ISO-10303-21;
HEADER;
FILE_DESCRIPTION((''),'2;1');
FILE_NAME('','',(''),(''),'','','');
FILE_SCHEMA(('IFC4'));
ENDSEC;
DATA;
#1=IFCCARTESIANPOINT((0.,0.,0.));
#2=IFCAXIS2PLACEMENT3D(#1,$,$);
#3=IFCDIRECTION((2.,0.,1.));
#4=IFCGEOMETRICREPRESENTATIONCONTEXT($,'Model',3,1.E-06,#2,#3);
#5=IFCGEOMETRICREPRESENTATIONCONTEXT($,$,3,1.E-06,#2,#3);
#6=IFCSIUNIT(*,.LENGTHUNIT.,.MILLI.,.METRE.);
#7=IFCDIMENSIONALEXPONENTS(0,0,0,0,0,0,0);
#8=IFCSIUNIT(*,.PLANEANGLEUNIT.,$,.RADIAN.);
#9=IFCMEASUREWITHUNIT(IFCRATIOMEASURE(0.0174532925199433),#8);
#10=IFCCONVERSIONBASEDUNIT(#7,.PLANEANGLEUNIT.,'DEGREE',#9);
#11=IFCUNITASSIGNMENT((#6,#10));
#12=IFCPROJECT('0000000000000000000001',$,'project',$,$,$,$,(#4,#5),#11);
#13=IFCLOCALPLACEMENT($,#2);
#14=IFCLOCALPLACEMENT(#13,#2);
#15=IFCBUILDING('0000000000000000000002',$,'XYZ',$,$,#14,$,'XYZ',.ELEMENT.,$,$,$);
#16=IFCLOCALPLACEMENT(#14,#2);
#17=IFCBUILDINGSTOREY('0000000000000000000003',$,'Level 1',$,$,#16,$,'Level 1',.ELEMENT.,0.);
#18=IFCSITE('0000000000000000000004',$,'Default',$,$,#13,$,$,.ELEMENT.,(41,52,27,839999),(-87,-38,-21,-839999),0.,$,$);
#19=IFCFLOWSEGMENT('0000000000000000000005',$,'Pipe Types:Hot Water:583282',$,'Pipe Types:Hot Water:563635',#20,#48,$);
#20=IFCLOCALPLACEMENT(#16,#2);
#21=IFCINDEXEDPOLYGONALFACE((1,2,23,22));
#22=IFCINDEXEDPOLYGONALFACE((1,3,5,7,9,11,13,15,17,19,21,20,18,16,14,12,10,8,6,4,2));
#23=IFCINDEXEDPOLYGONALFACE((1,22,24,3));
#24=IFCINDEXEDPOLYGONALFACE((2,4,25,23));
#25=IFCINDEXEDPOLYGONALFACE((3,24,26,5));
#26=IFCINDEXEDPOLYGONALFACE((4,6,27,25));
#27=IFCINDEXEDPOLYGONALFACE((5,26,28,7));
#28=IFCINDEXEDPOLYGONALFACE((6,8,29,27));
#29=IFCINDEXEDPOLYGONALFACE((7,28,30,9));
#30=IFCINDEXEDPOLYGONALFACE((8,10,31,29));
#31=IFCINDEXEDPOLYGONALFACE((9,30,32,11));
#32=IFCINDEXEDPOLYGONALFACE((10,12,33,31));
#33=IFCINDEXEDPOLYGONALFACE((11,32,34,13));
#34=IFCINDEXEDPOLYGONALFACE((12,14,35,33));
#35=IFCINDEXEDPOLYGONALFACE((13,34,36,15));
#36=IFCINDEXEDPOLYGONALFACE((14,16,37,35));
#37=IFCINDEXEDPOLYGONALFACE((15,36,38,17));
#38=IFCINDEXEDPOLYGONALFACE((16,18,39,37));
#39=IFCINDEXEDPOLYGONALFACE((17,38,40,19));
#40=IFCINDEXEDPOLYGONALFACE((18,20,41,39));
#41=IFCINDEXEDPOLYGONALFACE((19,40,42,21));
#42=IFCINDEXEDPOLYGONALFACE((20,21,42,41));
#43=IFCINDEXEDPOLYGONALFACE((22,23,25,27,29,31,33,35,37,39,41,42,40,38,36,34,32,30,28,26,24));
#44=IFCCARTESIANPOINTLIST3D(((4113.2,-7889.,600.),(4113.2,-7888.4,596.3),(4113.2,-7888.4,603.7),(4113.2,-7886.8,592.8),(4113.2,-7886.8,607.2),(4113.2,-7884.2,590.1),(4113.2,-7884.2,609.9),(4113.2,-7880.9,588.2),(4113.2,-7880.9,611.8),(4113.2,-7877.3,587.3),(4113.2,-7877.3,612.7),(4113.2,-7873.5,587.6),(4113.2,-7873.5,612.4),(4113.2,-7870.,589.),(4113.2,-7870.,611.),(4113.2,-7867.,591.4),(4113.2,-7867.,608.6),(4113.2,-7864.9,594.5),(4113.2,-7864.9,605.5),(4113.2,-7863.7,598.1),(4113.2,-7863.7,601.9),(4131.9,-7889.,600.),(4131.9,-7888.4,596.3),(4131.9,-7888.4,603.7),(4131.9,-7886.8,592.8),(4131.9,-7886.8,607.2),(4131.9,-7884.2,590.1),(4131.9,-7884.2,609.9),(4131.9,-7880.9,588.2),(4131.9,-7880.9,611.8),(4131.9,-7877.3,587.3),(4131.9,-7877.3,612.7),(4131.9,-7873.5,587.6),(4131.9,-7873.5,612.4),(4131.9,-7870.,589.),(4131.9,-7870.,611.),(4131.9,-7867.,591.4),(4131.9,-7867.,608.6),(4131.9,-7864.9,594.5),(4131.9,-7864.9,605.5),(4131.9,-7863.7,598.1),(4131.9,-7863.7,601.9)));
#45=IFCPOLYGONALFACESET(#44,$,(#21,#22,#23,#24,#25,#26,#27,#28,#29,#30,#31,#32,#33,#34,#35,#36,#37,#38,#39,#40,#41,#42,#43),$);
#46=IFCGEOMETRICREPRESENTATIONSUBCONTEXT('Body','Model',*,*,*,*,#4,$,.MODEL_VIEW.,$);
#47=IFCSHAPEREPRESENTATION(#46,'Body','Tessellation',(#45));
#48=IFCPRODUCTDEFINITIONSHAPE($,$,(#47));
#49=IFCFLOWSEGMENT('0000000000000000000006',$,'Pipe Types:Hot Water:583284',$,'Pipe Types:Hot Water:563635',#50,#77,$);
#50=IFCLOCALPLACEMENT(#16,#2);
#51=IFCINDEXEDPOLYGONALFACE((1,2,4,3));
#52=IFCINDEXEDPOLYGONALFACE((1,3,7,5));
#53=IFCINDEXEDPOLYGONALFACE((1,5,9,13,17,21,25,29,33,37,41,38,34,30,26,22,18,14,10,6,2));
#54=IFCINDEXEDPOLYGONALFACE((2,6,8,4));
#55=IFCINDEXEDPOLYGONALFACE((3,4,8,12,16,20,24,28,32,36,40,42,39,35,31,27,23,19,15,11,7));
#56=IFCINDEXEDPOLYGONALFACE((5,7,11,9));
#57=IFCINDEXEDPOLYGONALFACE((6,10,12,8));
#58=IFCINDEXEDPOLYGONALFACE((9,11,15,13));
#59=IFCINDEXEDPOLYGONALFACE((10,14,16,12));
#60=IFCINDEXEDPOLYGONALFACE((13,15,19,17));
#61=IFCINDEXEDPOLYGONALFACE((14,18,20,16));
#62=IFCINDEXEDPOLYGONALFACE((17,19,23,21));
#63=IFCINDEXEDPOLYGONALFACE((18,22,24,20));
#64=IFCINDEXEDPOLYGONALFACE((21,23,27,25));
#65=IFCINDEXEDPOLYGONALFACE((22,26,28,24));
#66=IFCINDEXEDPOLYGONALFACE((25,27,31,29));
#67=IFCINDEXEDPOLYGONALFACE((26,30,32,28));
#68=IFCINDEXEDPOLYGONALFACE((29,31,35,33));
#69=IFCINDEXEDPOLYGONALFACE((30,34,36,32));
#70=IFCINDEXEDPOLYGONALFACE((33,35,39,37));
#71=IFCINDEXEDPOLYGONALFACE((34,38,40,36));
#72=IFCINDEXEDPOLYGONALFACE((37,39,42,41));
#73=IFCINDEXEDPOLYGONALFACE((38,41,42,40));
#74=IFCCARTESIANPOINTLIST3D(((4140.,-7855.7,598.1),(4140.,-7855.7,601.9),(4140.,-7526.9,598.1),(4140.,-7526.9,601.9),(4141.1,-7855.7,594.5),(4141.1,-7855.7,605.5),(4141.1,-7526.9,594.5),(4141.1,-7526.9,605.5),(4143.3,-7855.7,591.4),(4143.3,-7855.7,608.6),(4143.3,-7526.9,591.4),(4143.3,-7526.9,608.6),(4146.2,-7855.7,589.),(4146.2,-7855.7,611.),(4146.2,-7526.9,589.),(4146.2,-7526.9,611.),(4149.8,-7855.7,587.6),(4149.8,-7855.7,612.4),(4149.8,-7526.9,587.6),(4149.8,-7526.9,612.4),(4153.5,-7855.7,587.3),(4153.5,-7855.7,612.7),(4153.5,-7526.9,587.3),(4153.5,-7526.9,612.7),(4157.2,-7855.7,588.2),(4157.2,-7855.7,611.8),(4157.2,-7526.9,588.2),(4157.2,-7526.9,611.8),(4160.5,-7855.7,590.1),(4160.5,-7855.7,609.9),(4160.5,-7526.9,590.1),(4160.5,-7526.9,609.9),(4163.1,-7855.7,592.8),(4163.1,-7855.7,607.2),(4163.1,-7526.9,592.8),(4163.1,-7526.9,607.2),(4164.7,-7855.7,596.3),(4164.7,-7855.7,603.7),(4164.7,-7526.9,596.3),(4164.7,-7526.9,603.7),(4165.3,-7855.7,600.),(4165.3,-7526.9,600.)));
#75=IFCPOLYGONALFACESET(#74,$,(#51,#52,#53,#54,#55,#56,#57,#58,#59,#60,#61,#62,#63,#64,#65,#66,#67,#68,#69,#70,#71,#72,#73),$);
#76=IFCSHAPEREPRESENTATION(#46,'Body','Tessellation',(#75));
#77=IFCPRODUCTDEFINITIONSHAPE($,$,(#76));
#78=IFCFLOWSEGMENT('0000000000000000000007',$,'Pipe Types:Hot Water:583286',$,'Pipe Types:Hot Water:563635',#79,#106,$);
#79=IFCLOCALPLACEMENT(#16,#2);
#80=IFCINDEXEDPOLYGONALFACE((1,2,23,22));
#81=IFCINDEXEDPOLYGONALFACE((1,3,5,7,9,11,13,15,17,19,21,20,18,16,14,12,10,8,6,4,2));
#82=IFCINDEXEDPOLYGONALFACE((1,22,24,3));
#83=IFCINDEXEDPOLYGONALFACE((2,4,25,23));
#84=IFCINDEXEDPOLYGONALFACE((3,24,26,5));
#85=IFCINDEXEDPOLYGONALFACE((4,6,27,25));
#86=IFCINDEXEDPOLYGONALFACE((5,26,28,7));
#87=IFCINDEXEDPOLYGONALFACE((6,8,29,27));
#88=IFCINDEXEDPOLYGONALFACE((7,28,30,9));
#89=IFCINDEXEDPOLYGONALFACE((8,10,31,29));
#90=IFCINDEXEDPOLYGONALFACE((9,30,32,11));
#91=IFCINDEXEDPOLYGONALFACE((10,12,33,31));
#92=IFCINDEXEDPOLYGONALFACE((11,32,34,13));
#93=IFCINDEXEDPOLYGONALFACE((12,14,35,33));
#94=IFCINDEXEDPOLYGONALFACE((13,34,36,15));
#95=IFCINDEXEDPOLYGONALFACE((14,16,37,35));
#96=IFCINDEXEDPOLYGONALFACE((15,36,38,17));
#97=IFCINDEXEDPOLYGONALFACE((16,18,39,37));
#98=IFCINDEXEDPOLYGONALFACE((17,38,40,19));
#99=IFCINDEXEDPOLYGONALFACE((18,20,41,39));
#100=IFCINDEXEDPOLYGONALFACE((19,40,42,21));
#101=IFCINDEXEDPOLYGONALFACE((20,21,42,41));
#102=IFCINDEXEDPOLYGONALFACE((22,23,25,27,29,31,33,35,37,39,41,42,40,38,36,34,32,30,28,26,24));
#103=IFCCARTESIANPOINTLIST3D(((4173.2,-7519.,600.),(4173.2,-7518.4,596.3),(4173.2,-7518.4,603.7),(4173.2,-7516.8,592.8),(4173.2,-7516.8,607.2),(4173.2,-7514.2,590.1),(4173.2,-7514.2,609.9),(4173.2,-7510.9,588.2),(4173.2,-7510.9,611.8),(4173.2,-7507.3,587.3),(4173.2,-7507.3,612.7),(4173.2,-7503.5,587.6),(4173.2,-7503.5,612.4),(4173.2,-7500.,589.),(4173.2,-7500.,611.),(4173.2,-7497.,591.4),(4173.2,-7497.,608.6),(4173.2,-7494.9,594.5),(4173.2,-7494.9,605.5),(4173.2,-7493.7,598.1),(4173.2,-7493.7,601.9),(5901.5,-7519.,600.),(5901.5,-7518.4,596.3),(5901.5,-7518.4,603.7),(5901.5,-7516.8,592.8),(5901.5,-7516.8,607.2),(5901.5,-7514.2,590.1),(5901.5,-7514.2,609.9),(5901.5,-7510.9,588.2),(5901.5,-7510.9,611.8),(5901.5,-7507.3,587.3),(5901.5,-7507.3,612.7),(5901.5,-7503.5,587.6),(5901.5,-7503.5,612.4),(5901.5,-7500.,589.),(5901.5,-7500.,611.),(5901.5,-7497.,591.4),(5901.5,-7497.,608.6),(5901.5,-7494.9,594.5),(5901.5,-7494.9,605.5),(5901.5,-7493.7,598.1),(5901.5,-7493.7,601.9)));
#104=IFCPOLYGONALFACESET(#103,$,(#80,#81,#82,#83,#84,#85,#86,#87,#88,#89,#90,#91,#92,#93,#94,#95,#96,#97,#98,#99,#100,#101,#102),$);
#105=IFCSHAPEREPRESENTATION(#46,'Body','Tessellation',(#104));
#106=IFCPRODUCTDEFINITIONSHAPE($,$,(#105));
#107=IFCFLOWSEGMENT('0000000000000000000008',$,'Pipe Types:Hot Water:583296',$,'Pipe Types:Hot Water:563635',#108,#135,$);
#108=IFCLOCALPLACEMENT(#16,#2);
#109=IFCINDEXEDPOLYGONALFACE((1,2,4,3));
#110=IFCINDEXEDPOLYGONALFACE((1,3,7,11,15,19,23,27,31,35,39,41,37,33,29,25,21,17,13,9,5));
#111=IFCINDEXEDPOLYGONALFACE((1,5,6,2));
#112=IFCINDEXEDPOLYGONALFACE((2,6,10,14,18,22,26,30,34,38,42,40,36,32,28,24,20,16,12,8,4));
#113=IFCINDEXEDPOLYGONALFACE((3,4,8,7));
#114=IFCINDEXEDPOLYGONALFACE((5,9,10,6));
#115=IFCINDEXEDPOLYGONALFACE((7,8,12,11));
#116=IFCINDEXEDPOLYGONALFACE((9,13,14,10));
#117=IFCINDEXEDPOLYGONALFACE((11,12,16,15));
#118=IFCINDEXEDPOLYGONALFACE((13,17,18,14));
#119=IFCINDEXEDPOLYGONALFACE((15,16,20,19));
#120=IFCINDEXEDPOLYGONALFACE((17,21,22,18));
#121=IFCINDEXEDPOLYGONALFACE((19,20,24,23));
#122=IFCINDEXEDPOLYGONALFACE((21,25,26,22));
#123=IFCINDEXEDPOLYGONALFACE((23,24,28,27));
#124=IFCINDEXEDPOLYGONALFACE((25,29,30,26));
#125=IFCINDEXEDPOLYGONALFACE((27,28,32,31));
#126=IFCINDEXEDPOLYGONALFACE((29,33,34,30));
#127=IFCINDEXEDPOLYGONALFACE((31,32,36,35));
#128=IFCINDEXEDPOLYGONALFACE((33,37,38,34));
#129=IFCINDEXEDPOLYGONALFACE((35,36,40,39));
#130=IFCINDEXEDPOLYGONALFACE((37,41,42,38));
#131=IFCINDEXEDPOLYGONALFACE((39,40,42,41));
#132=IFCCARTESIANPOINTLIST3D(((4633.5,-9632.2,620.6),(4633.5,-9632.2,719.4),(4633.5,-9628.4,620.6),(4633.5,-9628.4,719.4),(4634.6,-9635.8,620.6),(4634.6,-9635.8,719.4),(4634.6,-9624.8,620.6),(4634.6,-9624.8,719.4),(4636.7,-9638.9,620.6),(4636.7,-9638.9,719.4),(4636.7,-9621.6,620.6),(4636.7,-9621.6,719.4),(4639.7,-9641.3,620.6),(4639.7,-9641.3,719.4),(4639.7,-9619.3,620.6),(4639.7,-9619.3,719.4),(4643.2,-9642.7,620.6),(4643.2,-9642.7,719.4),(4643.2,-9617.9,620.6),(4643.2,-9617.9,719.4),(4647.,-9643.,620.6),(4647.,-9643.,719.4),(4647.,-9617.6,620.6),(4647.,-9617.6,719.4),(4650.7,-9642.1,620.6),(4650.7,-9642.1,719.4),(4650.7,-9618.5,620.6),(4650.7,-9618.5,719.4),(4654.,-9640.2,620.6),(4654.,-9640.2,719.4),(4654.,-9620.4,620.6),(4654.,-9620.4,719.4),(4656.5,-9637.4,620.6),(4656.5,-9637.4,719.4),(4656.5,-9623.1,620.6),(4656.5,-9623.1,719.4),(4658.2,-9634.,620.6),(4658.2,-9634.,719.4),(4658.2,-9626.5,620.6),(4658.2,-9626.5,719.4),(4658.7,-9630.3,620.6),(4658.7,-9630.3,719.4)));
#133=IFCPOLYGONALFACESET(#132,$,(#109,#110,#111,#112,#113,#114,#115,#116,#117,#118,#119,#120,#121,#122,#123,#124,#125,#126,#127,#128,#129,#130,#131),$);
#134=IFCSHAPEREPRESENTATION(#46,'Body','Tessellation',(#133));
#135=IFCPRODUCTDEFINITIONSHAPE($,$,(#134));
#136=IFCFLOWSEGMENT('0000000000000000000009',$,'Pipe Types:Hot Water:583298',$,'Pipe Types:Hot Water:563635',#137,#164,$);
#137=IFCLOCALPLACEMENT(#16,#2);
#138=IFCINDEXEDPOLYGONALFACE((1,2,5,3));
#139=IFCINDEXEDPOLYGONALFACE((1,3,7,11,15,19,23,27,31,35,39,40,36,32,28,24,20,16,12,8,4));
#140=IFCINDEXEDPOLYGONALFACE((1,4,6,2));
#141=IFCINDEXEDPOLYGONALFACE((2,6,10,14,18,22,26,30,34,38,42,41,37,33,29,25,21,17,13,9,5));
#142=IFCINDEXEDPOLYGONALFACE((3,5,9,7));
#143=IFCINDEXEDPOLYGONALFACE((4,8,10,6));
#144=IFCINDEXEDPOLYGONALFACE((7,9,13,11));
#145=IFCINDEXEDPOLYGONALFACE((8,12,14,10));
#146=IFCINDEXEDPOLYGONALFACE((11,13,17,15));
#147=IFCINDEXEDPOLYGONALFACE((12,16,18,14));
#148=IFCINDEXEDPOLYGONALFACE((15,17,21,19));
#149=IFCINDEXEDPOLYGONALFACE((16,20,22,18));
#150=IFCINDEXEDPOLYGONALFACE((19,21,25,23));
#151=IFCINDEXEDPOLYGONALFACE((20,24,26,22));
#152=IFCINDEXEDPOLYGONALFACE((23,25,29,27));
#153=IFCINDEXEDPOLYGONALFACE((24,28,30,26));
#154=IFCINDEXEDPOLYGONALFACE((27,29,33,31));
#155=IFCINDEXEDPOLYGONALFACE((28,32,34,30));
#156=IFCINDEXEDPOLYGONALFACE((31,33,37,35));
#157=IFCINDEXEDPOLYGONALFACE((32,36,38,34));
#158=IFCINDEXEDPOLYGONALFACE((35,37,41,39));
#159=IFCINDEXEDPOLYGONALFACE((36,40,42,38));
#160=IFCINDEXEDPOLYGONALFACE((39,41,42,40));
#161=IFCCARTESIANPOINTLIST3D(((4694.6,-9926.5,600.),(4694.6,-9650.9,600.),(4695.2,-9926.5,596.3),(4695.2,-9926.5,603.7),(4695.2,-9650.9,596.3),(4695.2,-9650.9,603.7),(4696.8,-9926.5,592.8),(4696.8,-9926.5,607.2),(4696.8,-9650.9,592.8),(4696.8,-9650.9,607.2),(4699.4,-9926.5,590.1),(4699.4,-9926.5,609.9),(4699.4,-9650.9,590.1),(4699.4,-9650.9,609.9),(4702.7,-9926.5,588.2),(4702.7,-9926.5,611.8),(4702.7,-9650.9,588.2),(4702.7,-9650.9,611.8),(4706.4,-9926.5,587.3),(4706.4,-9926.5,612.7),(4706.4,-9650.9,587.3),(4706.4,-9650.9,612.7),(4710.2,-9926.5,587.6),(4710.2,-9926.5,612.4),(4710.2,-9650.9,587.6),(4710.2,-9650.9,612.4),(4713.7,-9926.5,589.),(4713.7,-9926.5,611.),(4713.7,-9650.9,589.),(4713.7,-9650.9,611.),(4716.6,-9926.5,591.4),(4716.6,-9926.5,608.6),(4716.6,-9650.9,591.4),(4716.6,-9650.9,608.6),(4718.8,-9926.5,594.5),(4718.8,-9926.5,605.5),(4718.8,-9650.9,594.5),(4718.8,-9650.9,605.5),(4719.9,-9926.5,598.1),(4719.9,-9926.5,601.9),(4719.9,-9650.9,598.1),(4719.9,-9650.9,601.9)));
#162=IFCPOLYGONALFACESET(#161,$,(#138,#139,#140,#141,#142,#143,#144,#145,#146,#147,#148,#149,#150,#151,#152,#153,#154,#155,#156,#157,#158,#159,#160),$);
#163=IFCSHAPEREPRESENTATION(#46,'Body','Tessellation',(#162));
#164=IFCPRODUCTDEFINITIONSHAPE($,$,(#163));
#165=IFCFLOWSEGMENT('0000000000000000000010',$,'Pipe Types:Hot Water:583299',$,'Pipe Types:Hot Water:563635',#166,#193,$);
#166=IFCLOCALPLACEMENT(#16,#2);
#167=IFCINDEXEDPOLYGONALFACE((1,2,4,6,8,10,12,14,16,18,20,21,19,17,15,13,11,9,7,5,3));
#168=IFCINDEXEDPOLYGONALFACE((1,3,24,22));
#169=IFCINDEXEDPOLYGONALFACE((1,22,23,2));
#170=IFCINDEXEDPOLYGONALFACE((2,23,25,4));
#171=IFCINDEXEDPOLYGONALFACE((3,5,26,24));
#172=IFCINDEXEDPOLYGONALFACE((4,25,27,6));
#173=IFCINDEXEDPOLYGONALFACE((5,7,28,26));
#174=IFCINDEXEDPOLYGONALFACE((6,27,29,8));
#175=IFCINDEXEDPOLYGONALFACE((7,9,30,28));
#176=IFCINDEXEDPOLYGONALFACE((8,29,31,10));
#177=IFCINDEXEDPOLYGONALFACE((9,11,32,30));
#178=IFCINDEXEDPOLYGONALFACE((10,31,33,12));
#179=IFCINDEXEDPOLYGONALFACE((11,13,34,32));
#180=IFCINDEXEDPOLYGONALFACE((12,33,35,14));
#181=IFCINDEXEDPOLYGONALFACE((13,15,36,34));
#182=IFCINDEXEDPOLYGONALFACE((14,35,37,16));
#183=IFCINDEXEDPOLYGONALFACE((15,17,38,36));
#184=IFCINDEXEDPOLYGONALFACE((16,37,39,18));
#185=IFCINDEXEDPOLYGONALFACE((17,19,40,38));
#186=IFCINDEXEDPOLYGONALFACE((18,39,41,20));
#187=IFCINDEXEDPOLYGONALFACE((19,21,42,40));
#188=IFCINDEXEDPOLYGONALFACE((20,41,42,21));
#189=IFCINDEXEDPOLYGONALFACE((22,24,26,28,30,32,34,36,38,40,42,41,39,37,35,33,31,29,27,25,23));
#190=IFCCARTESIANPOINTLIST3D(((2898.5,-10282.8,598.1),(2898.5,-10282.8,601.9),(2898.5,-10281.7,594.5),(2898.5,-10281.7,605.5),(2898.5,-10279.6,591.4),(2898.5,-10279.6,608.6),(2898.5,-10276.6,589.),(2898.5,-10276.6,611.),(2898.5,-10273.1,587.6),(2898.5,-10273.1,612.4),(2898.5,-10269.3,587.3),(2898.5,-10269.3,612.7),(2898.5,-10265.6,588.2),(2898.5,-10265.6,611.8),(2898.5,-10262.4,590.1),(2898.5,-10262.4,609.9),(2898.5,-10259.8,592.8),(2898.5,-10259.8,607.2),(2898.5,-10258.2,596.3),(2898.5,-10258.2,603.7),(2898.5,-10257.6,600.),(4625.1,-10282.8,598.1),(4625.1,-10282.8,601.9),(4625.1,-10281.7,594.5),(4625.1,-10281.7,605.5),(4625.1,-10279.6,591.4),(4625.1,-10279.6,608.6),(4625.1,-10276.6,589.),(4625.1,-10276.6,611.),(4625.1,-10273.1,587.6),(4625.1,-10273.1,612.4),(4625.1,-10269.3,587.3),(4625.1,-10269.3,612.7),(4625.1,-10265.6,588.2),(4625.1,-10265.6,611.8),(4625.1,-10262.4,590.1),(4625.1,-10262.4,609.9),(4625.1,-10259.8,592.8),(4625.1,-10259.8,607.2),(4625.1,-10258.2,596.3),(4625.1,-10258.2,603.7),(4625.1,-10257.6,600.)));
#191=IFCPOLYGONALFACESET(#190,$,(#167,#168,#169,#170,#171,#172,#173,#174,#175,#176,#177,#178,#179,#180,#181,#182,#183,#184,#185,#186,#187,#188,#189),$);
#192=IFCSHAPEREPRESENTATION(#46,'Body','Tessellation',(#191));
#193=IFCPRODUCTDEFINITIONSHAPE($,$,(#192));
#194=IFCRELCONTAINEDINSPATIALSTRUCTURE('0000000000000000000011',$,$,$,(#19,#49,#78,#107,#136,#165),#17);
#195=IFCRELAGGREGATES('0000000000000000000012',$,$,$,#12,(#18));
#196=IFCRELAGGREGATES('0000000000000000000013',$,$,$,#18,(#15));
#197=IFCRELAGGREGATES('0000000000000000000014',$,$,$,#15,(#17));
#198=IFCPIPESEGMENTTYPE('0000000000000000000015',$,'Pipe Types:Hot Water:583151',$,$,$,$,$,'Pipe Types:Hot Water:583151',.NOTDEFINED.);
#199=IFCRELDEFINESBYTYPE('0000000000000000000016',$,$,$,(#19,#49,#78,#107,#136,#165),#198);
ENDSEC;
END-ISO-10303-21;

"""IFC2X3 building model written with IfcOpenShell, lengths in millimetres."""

from ifc_helpers import new_model, entity, si_unit, converted_unit, direction, frame, frame_2d, origin, origin_2d_with_axis, place, context, subcontext, project, spatial, circle, extrude, type_object, element, save


model = new_model("IFC2X3")

# Units and contexts
model_context = context("Model", 3, precision=1e-06, world=origin(), true_north=direction((2.0, 0.0, 1.0)))
context_of_model = context(None, 3, precision=1e-06, world=origin(), true_north=direction((2.0, 0.0, 1.0)))
body_context = subcontext(model_context, "Body", "Model", "MODEL_VIEW")
ifc_project = project(units=[si_unit("LENGTHUNIT", "METRE", prefix="MILLI"), converted_unit("PLANEANGLEUNIT", "DEGREE", entity("IfcRatioMeasure", 0.0174532925199433), si_unit("PLANEANGLEUNIT", "RADIAN"), dimensions=[0, 0, 0, 0, 0, 0, 0])], contexts=[model_context, context_of_model])

# Site, building, storey
site_placement = place(None, origin())
site = spatial("IfcSite", under=ifc_project, at=site_placement, Name="Default", CompositionType="ELEMENT", RefLatitude=(41, 52, 27, 839999), RefLongitude=(-87, -38, -21, -839999), RefElevation=0.0)
building_placement = place(site_placement, origin())
building = spatial("IfcBuilding", under=site, at=building_placement, Name="XYZ", LongName="XYZ", CompositionType="ELEMENT")
storey_placement = place(building_placement, origin())
storey = spatial("IfcBuildingStorey", under=building, at=storey_placement, Name="Level 1", LongName="Level 1", CompositionType="ELEMENT", Elevation=0.0)

# Flow segments
pipe_segment_type_1 = type_object("IfcPipeSegmentType", Name="Pipe Types:Hot Water:583151", ElementType="Pipe Types:Hot Water:583151", PredefinedType="NOTDEFINED")
flow_segment_1_placement = place(storey_placement, origin())
element("IfcFlowSegment", 1, at=flow_segment_1_placement, inside=storey, type_object=pipe_segment_type_1, Name="Pipe Types:Hot Water:583282", ObjectType="Pipe Types:Hot Water:563635", context=body_context, shape_type="SweptSolid", body=[
    extrude(circle(Radius=12.7, at=origin_2d_with_axis()), frame((4113.2, -7876.3, 600.0), z_axis=(1.0, 0.0, 0.0), x_axis=(0.0, -1.0, 0.0)), (0.0, 0.0, 1.0), 18.7),
])
flow_segment_2_placement = place(storey_placement, origin())
element("IfcFlowSegment", 2, at=flow_segment_2_placement, inside=storey, type_object=pipe_segment_type_1, Name="Pipe Types:Hot Water:583284", ObjectType="Pipe Types:Hot Water:563635", context=body_context, shape_type="SweptSolid", body=[
    extrude(circle(Radius=12.7, at=origin_2d_with_axis()), frame((4152.6, -7855.7, 600.0), z_axis=(0.0, 1.0, 0.0), x_axis=(1.0, 0.0, 0.0)), (0.0, 0.0, 1.0), 328.7),
])
flow_segment_3_placement = place(storey_placement, origin())
element("IfcFlowSegment", 3, at=flow_segment_3_placement, inside=storey, type_object=pipe_segment_type_1, Name="Pipe Types:Hot Water:583286", ObjectType="Pipe Types:Hot Water:563635", context=body_context, shape_type="SweptSolid", body=[
    extrude(circle(Radius=12.7, at=origin_2d_with_axis()), frame((4173.2, -7506.3, 600.0), z_axis=(1.0, 0.0, 0.0), x_axis=(0.0, -1.0, 0.0)), (0.0, 0.0, 1.0), 1728.3),
])
flow_segment_4_placement = place(storey_placement, origin())
element("IfcFlowSegment", 4, at=flow_segment_4_placement, inside=storey, type_object=pipe_segment_type_1, Name="Pipe Types:Hot Water:583296", ObjectType="Pipe Types:Hot Water:563635", context=body_context, shape_type="SweptSolid", body=[
    extrude(circle(Radius=12.7, at=origin_2d_with_axis()), frame((4646.0, -9630.3, 620.6)), (0.0, 0.0, 1.0), 98.7),
])
flow_segment_5_placement = place(storey_placement, origin())
element("IfcFlowSegment", 5, at=flow_segment_5_placement, inside=storey, type_object=pipe_segment_type_1, Name="Pipe Types:Hot Water:583298", ObjectType="Pipe Types:Hot Water:563635", context=body_context, shape_type="SweptSolid", body=[
    extrude(circle(Radius=12.7, at=frame_2d((0.0, 0.0), x_axis=(1.0, 0.0))), frame((4707.3, -9926.5, 600.0), z_axis=(0.0, 1.0, 0.0), x_axis=(-1.0, 0.0, 0.0)), (0.0, 0.0, 1.0), 275.6),
])
flow_segment_6_placement = place(storey_placement, origin())
element("IfcFlowSegment", 6, at=flow_segment_6_placement, inside=storey, type_object=pipe_segment_type_1, Name="Pipe Types:Hot Water:583299", ObjectType="Pipe Types:Hot Water:563635", context=body_context, shape_type="SweptSolid", body=[
    extrude(circle(Radius=12.7, at=frame_2d((0.0, 0.0), x_axis=(1.0, 0.0))), frame((2898.5, -10270.3, 600.0), z_axis=(1.0, 0.0, 0.0), x_axis=(0.0, 1.0, 0.0)), (0.0, 0.0, 1.0), 1726.6),
])

save(model, "model.ifc")
